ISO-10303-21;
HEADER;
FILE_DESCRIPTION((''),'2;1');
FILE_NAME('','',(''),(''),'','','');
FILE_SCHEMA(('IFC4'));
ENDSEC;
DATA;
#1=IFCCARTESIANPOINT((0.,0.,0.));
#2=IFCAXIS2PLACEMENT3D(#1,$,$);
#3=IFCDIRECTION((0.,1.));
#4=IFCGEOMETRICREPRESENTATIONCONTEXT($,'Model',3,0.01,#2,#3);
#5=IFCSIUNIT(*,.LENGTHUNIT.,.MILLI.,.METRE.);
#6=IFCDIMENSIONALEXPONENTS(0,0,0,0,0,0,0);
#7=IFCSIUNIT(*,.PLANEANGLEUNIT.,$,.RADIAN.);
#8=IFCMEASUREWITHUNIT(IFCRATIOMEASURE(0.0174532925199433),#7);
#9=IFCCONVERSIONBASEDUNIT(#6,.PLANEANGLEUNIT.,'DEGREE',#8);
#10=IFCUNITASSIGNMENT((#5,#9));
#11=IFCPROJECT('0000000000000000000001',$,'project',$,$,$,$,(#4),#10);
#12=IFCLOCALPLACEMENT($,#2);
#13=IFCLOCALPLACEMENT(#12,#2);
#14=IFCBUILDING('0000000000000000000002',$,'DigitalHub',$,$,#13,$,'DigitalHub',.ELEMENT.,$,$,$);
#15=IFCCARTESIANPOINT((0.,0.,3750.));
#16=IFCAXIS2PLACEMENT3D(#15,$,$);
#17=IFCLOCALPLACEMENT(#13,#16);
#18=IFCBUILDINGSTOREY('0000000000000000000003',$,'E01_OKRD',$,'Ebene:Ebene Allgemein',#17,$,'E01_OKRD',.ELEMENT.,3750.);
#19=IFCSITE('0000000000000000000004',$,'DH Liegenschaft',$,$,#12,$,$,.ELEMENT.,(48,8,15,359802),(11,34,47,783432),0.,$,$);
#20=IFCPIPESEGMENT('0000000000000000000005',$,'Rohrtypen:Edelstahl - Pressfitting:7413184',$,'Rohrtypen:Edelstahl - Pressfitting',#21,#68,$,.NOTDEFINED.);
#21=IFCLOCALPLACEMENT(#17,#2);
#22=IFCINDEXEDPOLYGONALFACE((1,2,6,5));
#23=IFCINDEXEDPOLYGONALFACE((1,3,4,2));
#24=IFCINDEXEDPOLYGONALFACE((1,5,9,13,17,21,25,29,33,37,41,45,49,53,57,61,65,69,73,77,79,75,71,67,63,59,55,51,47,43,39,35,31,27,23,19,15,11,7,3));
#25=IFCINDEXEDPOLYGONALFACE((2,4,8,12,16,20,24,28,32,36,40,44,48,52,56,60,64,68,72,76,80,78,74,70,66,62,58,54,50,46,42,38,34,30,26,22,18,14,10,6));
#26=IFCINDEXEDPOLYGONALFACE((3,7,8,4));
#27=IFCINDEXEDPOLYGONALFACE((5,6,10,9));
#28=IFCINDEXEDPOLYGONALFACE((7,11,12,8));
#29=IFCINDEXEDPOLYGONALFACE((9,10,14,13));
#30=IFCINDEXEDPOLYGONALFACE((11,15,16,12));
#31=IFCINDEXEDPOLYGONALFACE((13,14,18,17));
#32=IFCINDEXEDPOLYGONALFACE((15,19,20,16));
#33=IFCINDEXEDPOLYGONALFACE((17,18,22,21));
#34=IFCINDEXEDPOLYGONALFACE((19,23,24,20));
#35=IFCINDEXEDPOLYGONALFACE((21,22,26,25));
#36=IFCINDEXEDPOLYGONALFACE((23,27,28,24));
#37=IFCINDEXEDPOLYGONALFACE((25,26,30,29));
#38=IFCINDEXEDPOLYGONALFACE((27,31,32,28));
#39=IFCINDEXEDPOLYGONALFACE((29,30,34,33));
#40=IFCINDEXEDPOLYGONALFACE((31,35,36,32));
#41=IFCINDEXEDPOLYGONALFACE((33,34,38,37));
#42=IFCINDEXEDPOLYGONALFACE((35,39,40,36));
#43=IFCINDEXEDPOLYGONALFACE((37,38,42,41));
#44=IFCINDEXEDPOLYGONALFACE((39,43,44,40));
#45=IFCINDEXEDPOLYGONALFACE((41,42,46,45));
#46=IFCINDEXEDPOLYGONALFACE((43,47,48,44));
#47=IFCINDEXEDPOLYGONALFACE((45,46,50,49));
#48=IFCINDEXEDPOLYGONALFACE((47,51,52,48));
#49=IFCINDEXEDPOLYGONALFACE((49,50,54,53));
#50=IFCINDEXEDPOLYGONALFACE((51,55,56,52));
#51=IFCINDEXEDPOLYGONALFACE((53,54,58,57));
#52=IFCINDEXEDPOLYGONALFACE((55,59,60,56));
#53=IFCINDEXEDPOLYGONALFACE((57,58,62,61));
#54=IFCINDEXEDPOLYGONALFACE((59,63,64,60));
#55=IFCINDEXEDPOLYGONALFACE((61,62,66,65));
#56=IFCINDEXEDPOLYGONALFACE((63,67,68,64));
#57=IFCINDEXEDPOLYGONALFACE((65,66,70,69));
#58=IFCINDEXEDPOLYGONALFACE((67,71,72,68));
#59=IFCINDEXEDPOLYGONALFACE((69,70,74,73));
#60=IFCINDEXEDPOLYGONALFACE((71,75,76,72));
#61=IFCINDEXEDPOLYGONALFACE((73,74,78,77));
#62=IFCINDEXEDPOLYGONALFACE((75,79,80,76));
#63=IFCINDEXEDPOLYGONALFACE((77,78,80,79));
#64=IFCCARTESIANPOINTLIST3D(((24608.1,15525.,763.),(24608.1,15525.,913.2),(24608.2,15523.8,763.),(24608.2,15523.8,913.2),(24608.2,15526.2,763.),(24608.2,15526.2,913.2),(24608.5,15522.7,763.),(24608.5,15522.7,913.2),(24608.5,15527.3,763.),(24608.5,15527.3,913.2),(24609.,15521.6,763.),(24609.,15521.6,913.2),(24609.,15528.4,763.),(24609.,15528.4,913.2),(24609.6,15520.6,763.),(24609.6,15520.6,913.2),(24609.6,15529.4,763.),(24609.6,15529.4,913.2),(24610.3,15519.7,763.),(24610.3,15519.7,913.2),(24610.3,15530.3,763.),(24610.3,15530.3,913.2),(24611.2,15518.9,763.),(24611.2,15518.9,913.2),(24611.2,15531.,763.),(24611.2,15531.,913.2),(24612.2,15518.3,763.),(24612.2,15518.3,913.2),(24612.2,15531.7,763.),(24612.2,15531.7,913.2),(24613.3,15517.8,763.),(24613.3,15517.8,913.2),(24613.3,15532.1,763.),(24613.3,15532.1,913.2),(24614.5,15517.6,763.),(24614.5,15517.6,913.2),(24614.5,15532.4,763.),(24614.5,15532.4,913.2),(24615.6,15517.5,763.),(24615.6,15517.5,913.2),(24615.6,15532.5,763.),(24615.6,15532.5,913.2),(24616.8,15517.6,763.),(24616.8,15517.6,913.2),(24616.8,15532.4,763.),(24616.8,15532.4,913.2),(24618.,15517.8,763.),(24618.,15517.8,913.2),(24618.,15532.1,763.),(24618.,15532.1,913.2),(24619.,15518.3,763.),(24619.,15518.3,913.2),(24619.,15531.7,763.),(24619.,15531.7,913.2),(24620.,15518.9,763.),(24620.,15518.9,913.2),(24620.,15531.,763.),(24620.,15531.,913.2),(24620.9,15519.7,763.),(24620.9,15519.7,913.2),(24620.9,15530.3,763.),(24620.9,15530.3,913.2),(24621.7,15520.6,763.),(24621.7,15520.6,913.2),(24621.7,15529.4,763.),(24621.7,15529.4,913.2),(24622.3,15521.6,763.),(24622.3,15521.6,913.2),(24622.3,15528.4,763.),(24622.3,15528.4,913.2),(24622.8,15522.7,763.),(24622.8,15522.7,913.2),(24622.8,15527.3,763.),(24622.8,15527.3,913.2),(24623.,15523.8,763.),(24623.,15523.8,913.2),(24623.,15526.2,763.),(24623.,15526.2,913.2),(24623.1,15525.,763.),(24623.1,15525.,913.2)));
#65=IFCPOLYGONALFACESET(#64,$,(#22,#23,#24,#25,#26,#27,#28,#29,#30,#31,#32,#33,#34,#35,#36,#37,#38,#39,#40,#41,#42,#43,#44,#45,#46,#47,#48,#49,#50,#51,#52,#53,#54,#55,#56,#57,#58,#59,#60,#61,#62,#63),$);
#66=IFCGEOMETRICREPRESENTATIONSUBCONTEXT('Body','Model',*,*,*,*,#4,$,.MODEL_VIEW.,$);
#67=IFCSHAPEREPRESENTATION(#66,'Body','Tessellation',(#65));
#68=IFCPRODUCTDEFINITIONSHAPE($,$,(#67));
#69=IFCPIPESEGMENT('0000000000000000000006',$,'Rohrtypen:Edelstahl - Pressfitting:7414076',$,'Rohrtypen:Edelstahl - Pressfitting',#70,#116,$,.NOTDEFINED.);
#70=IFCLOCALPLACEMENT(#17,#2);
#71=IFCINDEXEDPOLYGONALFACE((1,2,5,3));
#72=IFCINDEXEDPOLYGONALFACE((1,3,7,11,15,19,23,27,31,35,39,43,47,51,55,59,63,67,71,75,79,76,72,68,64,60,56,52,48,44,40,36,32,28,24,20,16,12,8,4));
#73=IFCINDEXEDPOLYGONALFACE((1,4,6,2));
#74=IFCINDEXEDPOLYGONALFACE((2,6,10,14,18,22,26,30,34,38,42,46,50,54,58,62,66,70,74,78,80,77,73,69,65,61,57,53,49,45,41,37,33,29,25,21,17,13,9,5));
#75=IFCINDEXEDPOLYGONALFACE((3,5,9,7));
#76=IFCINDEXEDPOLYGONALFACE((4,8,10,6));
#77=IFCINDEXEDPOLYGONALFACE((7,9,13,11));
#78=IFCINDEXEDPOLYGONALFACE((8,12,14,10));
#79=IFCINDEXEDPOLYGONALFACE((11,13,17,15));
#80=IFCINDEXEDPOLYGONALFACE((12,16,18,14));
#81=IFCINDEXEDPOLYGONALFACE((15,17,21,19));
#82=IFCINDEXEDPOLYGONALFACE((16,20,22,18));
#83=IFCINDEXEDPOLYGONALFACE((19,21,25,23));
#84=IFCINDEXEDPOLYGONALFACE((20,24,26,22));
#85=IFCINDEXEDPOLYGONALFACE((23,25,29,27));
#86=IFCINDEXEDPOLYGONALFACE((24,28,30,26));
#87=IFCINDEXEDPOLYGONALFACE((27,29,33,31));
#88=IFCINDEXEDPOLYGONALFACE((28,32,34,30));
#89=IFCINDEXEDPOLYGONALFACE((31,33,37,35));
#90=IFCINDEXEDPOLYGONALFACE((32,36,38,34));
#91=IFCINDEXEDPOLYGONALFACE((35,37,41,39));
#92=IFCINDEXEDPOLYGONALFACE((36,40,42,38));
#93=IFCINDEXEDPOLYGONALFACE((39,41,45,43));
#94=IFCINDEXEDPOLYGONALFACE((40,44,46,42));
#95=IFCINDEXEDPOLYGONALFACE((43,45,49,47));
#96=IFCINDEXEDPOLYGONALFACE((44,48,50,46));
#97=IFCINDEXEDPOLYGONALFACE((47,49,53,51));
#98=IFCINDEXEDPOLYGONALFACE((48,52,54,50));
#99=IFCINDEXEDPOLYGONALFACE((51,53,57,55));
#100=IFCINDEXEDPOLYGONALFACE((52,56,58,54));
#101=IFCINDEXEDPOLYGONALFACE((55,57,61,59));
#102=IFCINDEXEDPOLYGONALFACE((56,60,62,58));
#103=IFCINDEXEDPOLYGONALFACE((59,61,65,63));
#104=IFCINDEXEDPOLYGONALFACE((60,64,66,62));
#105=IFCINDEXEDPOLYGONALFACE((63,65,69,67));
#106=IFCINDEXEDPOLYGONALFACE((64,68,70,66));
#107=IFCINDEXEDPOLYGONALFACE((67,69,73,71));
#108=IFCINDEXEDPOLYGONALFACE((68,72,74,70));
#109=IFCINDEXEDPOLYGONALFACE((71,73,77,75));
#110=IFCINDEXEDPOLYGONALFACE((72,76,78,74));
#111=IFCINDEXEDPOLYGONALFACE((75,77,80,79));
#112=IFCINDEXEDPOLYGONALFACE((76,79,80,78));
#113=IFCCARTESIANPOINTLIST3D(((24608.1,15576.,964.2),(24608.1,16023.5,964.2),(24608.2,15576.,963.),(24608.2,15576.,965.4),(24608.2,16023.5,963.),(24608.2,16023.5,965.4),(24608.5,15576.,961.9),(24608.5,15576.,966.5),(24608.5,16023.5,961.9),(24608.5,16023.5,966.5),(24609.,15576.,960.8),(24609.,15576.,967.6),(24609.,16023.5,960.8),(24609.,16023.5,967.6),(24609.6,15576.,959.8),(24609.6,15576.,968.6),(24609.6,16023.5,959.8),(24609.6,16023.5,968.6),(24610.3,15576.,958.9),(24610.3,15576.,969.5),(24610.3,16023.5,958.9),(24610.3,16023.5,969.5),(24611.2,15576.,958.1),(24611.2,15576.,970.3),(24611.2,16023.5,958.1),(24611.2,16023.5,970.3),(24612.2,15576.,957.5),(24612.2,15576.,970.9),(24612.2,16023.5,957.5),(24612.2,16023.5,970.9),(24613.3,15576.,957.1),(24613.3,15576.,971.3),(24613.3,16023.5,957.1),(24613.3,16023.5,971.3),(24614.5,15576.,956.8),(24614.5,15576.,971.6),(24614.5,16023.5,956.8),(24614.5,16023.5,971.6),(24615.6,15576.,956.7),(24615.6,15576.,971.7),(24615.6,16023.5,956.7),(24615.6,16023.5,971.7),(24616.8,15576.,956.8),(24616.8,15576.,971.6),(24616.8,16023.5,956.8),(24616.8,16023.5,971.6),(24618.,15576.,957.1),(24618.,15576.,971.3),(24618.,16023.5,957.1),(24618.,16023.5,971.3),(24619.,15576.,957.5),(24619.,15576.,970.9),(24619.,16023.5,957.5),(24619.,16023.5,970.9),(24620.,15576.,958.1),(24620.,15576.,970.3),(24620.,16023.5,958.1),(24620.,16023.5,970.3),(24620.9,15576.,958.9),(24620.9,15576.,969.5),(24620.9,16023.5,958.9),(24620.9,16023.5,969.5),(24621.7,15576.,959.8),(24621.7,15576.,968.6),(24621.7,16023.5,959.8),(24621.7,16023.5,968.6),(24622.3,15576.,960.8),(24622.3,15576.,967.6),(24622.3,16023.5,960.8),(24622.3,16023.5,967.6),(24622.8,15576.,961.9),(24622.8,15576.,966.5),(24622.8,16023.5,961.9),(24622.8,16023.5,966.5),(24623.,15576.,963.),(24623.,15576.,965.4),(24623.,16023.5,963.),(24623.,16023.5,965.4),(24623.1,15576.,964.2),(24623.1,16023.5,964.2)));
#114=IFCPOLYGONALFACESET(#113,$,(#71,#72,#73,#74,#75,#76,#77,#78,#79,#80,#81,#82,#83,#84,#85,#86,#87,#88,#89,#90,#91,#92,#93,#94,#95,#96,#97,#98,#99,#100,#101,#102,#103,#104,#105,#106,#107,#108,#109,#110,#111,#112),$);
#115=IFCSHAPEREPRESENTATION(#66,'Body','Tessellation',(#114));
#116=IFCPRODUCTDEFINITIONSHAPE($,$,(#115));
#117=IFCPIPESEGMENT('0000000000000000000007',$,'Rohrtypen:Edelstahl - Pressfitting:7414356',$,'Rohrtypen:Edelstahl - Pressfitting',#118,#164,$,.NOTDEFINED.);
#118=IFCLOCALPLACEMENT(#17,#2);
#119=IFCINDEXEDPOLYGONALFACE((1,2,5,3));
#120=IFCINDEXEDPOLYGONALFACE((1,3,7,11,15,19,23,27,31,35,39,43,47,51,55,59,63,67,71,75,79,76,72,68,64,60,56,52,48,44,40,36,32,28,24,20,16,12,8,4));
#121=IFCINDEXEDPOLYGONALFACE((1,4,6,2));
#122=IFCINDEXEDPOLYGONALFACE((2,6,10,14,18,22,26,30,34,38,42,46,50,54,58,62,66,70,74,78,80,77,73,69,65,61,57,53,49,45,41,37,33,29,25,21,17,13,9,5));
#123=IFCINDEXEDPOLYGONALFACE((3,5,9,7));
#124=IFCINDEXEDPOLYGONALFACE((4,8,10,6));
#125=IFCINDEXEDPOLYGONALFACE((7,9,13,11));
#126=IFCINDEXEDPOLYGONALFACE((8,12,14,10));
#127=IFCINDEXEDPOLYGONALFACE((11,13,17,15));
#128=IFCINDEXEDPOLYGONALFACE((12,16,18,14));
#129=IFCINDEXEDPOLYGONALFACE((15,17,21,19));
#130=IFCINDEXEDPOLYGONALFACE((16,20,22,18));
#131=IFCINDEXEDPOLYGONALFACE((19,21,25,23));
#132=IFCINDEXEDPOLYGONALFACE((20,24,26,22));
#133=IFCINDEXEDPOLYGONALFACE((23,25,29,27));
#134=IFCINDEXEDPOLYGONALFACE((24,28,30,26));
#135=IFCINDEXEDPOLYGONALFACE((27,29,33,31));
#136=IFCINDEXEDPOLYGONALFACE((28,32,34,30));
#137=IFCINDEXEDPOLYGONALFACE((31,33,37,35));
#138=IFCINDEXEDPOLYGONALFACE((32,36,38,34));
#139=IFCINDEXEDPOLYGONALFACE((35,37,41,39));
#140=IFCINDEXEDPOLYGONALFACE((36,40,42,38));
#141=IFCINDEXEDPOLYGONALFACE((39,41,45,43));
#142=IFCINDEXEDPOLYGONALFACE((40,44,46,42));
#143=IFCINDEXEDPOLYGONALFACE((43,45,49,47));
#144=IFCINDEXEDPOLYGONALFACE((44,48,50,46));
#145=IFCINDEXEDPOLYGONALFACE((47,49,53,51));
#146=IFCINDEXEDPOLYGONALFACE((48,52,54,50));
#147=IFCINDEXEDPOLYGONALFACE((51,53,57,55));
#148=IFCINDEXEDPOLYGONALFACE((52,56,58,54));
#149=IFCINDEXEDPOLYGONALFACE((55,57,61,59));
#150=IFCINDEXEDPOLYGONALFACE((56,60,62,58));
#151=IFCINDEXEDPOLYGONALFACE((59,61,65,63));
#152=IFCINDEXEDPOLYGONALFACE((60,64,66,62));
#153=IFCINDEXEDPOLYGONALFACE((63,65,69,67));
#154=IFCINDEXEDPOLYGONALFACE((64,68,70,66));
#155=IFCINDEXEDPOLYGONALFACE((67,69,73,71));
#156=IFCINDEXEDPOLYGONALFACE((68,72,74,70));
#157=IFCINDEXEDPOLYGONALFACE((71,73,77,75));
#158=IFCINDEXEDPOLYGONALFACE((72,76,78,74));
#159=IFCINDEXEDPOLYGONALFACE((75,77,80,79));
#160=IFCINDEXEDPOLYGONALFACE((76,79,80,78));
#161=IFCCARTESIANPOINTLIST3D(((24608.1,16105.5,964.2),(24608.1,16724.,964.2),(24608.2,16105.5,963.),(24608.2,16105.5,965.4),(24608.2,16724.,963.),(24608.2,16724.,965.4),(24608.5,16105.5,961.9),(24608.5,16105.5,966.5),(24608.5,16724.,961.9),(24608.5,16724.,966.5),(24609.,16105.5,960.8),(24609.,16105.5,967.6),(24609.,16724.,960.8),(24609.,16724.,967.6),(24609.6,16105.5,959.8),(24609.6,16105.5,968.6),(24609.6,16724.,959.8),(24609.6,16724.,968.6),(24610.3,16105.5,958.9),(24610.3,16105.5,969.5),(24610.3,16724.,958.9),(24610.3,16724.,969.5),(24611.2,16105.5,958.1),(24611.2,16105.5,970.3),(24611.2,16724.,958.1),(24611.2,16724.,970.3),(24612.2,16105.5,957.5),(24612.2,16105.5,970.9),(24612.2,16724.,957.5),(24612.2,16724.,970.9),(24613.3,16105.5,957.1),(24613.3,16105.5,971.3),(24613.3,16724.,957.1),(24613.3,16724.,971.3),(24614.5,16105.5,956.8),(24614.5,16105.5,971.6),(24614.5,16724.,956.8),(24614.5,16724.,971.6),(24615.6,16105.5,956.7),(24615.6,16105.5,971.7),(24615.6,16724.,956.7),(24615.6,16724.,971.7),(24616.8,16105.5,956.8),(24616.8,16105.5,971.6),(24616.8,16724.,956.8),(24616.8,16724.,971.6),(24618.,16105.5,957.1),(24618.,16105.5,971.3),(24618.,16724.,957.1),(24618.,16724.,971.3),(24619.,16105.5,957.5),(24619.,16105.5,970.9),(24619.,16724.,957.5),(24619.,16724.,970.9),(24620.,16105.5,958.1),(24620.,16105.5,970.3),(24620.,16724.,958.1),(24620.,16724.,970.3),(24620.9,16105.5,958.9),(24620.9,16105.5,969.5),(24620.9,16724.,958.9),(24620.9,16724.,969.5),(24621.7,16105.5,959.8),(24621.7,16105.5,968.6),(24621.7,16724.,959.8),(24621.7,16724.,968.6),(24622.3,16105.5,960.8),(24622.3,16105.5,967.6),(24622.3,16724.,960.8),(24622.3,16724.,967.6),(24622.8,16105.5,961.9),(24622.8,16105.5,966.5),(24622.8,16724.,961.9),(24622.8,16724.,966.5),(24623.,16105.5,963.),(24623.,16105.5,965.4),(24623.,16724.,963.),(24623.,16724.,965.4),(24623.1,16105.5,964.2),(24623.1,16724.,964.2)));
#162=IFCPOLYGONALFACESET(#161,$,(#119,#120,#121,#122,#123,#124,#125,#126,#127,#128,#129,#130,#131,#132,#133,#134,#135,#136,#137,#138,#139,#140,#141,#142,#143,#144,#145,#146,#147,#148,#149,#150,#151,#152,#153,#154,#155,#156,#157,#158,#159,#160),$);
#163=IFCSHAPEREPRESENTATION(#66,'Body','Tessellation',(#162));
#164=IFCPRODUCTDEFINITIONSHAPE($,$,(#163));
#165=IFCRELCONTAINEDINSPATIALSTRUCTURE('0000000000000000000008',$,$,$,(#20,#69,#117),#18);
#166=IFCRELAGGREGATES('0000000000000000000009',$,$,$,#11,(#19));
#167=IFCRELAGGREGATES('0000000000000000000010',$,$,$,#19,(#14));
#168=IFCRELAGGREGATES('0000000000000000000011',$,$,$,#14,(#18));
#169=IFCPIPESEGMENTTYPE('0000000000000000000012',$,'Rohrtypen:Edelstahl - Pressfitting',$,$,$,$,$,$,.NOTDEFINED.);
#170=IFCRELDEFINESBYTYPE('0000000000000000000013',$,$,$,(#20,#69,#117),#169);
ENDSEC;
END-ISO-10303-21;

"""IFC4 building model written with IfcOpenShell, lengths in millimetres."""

from ifc_helpers import new_model, entity, si_unit, converted_unit, direction, frame, origin, place, context, subcontext, project, spatial, indexed_curve, outline, extrude, type_object, element, save


model = new_model("IFC4")

# Units and contexts
model_context = context("Model", 3, precision=0.01, world=origin(), true_north=direction((0.0, 1.0)))
body_context = subcontext(model_context, "Body", "Model", "MODEL_VIEW")
ifc_project = project(units=[si_unit("LENGTHUNIT", "METRE", prefix="MILLI"), converted_unit("PLANEANGLEUNIT", "DEGREE", entity("IfcRatioMeasure", 0.0174532925199433), si_unit("PLANEANGLEUNIT", "RADIAN"), dimensions=[0, 0, 0, 0, 0, 0, 0])], contexts=[model_context])

# Site, building, storey
site_placement = place(None, origin())
site = spatial("IfcSite", under=ifc_project, at=site_placement, Name="DH Liegenschaft", CompositionType="ELEMENT", RefLatitude=(48, 8, 15, 359802), RefLongitude=(11, 34, 47, 783432), RefElevation=0.0)
building_placement = place(site_placement, origin())
building = spatial("IfcBuilding", under=site, at=building_placement, Name="DigitalHub", LongName="DigitalHub", CompositionType="ELEMENT")
storey_placement = place(building_placement, frame((0.0, 0.0, 3750.0)))
storey = spatial("IfcBuildingStorey", under=building, at=storey_placement, Name="E01_OKRD", ObjectType="Ebene:Ebene Allgemein", LongName="E01_OKRD", CompositionType="ELEMENT", Elevation=3750.0)

# Pipe segments
pipe_segment_type_1 = type_object("IfcPipeSegmentType", Name="Rohrtypen:Edelstahl - Pressfitting", PredefinedType="NOTDEFINED")
pipe_segment_1_placement = place(storey_placement, frame((24606.5, 15515.9, 763.0)))
element("IfcPipeSegment", 1, at=pipe_segment_1_placement, inside=storey, type_object=pipe_segment_type_1, Name="Rohrtypen:Edelstahl - Pressfitting:7413184", ObjectType="Rohrtypen:Edelstahl - Pressfitting", PredefinedType="NOTDEFINED", context=body_context, shape_type="SweptSolid", body=[
    extrude(outline(indexed_curve([(7.5, 0.0), (7.4, 1.2), (7.1, 2.3), (6.7, 3.4), (6.1, 4.4), (5.3, 5.3), (4.4, 6.1), (3.4, 6.7), (2.3, 7.1), (1.2, 7.4), (0.0, 7.5), (-1.2, 7.4), (-2.3, 7.1), (-3.4, 6.7), (-4.4, 6.1), (-5.3, 5.3), (-6.1, 4.4), (-6.7, 3.4), (-7.1, 2.3), (-7.4, 1.2), (-7.5, 0.0), (-7.4, -1.2), (-7.1, -2.3), (-6.7, -3.4), (-6.1, -4.4), (-5.3, -5.3), (-4.4, -6.1), (-3.4, -6.7), (-2.3, -7.1), (-1.2, -7.4), (0.0, -7.5), (1.2, -7.4), (2.3, -7.1), (3.4, -6.7), (4.4, -6.1), (5.3, -5.3), (6.1, -4.4), (6.7, -3.4), (7.1, -2.3), (7.4, -1.2), (7.5, 0.0)], self_intersect=False)), frame((9.1, 9.1, 0.0), z_axis=(0.0, 0.0, 1.0), x_axis=(-1.0, 0.0, 0.0)), (0.0, 0.0, 1.0), 150.2),
])
pipe_segment_2_placement = place(storey_placement, frame((24606.5, 15576.0, 955.1)))
element("IfcPipeSegment", 2, at=pipe_segment_2_placement, inside=storey, type_object=pipe_segment_type_1, Name="Rohrtypen:Edelstahl - Pressfitting:7414076", ObjectType="Rohrtypen:Edelstahl - Pressfitting", PredefinedType="NOTDEFINED", context=body_context, shape_type="SweptSolid", body=[
    extrude(outline(indexed_curve([(7.5, 0.0), (7.4, 1.2), (7.1, 2.3), (6.7, 3.4), (6.1, 4.4), (5.3, 5.3), (4.4, 6.1), (3.4, 6.7), (2.3, 7.1), (1.2, 7.4), (0.0, 7.5), (-1.2, 7.4), (-2.3, 7.1), (-3.4, 6.7), (-4.4, 6.1), (-5.3, 5.3), (-6.1, 4.4), (-6.7, 3.4), (-7.1, 2.3), (-7.4, 1.2), (-7.5, 0.0), (-7.4, -1.2), (-7.1, -2.3), (-6.7, -3.4), (-6.1, -4.4), (-5.3, -5.3), (-4.4, -6.1), (-3.4, -6.7), (-2.3, -7.1), (-1.2, -7.4), (0.0, -7.5), (1.2, -7.4), (2.3, -7.1), (3.4, -6.7), (4.4, -6.1), (5.3, -5.3), (6.1, -4.4), (6.7, -3.4), (7.1, -2.3), (7.4, -1.2), (7.5, 0.0)], self_intersect=False)), frame((9.1, 0.0, 9.1), z_axis=(0.000013, 1.0, 0.0), x_axis=(-1.0, 0.000013, 0.0)), (0.0, 0.0, 1.0), 447.5),
])
pipe_segment_3_placement = place(storey_placement, frame((24606.5, 16105.5, 955.1)))
element("IfcPipeSegment", 3, at=pipe_segment_3_placement, inside=storey, type_object=pipe_segment_type_1, Name="Rohrtypen:Edelstahl - Pressfitting:7414356", ObjectType="Rohrtypen:Edelstahl - Pressfitting", PredefinedType="NOTDEFINED", context=body_context, shape_type="SweptSolid", body=[
    extrude(outline(indexed_curve([(7.5, 0.0), (7.4, 1.2), (7.1, 2.3), (6.7, 3.4), (6.1, 4.4), (5.3, 5.3), (4.4, 6.1), (3.4, 6.7), (2.3, 7.1), (1.2, 7.4), (0.0, 7.5), (-1.2, 7.4), (-2.3, 7.1), (-3.4, 6.7), (-4.4, 6.1), (-5.3, 5.3), (-6.1, 4.4), (-6.7, 3.4), (-7.1, 2.3), (-7.4, 1.2), (-7.5, 0.0), (-7.4, -1.2), (-7.1, -2.3), (-6.7, -3.4), (-6.1, -4.4), (-5.3, -5.3), (-4.4, -6.1), (-3.4, -6.7), (-2.3, -7.1), (-1.2, -7.4), (0.0, -7.5), (1.2, -7.4), (2.3, -7.1), (3.4, -6.7), (4.4, -6.1), (5.3, -5.3), (6.1, -4.4), (6.7, -3.4), (7.1, -2.3), (7.4, -1.2), (7.5, 0.0)], self_intersect=False)), frame((9.1, 0.0, 9.1), z_axis=(0.000001, 1.0, 0.0), x_axis=(-1.0, 0.000001, 0.0)), (0.0, 0.0, 1.0), 618.5),
])

save(model, "model.ifc")
